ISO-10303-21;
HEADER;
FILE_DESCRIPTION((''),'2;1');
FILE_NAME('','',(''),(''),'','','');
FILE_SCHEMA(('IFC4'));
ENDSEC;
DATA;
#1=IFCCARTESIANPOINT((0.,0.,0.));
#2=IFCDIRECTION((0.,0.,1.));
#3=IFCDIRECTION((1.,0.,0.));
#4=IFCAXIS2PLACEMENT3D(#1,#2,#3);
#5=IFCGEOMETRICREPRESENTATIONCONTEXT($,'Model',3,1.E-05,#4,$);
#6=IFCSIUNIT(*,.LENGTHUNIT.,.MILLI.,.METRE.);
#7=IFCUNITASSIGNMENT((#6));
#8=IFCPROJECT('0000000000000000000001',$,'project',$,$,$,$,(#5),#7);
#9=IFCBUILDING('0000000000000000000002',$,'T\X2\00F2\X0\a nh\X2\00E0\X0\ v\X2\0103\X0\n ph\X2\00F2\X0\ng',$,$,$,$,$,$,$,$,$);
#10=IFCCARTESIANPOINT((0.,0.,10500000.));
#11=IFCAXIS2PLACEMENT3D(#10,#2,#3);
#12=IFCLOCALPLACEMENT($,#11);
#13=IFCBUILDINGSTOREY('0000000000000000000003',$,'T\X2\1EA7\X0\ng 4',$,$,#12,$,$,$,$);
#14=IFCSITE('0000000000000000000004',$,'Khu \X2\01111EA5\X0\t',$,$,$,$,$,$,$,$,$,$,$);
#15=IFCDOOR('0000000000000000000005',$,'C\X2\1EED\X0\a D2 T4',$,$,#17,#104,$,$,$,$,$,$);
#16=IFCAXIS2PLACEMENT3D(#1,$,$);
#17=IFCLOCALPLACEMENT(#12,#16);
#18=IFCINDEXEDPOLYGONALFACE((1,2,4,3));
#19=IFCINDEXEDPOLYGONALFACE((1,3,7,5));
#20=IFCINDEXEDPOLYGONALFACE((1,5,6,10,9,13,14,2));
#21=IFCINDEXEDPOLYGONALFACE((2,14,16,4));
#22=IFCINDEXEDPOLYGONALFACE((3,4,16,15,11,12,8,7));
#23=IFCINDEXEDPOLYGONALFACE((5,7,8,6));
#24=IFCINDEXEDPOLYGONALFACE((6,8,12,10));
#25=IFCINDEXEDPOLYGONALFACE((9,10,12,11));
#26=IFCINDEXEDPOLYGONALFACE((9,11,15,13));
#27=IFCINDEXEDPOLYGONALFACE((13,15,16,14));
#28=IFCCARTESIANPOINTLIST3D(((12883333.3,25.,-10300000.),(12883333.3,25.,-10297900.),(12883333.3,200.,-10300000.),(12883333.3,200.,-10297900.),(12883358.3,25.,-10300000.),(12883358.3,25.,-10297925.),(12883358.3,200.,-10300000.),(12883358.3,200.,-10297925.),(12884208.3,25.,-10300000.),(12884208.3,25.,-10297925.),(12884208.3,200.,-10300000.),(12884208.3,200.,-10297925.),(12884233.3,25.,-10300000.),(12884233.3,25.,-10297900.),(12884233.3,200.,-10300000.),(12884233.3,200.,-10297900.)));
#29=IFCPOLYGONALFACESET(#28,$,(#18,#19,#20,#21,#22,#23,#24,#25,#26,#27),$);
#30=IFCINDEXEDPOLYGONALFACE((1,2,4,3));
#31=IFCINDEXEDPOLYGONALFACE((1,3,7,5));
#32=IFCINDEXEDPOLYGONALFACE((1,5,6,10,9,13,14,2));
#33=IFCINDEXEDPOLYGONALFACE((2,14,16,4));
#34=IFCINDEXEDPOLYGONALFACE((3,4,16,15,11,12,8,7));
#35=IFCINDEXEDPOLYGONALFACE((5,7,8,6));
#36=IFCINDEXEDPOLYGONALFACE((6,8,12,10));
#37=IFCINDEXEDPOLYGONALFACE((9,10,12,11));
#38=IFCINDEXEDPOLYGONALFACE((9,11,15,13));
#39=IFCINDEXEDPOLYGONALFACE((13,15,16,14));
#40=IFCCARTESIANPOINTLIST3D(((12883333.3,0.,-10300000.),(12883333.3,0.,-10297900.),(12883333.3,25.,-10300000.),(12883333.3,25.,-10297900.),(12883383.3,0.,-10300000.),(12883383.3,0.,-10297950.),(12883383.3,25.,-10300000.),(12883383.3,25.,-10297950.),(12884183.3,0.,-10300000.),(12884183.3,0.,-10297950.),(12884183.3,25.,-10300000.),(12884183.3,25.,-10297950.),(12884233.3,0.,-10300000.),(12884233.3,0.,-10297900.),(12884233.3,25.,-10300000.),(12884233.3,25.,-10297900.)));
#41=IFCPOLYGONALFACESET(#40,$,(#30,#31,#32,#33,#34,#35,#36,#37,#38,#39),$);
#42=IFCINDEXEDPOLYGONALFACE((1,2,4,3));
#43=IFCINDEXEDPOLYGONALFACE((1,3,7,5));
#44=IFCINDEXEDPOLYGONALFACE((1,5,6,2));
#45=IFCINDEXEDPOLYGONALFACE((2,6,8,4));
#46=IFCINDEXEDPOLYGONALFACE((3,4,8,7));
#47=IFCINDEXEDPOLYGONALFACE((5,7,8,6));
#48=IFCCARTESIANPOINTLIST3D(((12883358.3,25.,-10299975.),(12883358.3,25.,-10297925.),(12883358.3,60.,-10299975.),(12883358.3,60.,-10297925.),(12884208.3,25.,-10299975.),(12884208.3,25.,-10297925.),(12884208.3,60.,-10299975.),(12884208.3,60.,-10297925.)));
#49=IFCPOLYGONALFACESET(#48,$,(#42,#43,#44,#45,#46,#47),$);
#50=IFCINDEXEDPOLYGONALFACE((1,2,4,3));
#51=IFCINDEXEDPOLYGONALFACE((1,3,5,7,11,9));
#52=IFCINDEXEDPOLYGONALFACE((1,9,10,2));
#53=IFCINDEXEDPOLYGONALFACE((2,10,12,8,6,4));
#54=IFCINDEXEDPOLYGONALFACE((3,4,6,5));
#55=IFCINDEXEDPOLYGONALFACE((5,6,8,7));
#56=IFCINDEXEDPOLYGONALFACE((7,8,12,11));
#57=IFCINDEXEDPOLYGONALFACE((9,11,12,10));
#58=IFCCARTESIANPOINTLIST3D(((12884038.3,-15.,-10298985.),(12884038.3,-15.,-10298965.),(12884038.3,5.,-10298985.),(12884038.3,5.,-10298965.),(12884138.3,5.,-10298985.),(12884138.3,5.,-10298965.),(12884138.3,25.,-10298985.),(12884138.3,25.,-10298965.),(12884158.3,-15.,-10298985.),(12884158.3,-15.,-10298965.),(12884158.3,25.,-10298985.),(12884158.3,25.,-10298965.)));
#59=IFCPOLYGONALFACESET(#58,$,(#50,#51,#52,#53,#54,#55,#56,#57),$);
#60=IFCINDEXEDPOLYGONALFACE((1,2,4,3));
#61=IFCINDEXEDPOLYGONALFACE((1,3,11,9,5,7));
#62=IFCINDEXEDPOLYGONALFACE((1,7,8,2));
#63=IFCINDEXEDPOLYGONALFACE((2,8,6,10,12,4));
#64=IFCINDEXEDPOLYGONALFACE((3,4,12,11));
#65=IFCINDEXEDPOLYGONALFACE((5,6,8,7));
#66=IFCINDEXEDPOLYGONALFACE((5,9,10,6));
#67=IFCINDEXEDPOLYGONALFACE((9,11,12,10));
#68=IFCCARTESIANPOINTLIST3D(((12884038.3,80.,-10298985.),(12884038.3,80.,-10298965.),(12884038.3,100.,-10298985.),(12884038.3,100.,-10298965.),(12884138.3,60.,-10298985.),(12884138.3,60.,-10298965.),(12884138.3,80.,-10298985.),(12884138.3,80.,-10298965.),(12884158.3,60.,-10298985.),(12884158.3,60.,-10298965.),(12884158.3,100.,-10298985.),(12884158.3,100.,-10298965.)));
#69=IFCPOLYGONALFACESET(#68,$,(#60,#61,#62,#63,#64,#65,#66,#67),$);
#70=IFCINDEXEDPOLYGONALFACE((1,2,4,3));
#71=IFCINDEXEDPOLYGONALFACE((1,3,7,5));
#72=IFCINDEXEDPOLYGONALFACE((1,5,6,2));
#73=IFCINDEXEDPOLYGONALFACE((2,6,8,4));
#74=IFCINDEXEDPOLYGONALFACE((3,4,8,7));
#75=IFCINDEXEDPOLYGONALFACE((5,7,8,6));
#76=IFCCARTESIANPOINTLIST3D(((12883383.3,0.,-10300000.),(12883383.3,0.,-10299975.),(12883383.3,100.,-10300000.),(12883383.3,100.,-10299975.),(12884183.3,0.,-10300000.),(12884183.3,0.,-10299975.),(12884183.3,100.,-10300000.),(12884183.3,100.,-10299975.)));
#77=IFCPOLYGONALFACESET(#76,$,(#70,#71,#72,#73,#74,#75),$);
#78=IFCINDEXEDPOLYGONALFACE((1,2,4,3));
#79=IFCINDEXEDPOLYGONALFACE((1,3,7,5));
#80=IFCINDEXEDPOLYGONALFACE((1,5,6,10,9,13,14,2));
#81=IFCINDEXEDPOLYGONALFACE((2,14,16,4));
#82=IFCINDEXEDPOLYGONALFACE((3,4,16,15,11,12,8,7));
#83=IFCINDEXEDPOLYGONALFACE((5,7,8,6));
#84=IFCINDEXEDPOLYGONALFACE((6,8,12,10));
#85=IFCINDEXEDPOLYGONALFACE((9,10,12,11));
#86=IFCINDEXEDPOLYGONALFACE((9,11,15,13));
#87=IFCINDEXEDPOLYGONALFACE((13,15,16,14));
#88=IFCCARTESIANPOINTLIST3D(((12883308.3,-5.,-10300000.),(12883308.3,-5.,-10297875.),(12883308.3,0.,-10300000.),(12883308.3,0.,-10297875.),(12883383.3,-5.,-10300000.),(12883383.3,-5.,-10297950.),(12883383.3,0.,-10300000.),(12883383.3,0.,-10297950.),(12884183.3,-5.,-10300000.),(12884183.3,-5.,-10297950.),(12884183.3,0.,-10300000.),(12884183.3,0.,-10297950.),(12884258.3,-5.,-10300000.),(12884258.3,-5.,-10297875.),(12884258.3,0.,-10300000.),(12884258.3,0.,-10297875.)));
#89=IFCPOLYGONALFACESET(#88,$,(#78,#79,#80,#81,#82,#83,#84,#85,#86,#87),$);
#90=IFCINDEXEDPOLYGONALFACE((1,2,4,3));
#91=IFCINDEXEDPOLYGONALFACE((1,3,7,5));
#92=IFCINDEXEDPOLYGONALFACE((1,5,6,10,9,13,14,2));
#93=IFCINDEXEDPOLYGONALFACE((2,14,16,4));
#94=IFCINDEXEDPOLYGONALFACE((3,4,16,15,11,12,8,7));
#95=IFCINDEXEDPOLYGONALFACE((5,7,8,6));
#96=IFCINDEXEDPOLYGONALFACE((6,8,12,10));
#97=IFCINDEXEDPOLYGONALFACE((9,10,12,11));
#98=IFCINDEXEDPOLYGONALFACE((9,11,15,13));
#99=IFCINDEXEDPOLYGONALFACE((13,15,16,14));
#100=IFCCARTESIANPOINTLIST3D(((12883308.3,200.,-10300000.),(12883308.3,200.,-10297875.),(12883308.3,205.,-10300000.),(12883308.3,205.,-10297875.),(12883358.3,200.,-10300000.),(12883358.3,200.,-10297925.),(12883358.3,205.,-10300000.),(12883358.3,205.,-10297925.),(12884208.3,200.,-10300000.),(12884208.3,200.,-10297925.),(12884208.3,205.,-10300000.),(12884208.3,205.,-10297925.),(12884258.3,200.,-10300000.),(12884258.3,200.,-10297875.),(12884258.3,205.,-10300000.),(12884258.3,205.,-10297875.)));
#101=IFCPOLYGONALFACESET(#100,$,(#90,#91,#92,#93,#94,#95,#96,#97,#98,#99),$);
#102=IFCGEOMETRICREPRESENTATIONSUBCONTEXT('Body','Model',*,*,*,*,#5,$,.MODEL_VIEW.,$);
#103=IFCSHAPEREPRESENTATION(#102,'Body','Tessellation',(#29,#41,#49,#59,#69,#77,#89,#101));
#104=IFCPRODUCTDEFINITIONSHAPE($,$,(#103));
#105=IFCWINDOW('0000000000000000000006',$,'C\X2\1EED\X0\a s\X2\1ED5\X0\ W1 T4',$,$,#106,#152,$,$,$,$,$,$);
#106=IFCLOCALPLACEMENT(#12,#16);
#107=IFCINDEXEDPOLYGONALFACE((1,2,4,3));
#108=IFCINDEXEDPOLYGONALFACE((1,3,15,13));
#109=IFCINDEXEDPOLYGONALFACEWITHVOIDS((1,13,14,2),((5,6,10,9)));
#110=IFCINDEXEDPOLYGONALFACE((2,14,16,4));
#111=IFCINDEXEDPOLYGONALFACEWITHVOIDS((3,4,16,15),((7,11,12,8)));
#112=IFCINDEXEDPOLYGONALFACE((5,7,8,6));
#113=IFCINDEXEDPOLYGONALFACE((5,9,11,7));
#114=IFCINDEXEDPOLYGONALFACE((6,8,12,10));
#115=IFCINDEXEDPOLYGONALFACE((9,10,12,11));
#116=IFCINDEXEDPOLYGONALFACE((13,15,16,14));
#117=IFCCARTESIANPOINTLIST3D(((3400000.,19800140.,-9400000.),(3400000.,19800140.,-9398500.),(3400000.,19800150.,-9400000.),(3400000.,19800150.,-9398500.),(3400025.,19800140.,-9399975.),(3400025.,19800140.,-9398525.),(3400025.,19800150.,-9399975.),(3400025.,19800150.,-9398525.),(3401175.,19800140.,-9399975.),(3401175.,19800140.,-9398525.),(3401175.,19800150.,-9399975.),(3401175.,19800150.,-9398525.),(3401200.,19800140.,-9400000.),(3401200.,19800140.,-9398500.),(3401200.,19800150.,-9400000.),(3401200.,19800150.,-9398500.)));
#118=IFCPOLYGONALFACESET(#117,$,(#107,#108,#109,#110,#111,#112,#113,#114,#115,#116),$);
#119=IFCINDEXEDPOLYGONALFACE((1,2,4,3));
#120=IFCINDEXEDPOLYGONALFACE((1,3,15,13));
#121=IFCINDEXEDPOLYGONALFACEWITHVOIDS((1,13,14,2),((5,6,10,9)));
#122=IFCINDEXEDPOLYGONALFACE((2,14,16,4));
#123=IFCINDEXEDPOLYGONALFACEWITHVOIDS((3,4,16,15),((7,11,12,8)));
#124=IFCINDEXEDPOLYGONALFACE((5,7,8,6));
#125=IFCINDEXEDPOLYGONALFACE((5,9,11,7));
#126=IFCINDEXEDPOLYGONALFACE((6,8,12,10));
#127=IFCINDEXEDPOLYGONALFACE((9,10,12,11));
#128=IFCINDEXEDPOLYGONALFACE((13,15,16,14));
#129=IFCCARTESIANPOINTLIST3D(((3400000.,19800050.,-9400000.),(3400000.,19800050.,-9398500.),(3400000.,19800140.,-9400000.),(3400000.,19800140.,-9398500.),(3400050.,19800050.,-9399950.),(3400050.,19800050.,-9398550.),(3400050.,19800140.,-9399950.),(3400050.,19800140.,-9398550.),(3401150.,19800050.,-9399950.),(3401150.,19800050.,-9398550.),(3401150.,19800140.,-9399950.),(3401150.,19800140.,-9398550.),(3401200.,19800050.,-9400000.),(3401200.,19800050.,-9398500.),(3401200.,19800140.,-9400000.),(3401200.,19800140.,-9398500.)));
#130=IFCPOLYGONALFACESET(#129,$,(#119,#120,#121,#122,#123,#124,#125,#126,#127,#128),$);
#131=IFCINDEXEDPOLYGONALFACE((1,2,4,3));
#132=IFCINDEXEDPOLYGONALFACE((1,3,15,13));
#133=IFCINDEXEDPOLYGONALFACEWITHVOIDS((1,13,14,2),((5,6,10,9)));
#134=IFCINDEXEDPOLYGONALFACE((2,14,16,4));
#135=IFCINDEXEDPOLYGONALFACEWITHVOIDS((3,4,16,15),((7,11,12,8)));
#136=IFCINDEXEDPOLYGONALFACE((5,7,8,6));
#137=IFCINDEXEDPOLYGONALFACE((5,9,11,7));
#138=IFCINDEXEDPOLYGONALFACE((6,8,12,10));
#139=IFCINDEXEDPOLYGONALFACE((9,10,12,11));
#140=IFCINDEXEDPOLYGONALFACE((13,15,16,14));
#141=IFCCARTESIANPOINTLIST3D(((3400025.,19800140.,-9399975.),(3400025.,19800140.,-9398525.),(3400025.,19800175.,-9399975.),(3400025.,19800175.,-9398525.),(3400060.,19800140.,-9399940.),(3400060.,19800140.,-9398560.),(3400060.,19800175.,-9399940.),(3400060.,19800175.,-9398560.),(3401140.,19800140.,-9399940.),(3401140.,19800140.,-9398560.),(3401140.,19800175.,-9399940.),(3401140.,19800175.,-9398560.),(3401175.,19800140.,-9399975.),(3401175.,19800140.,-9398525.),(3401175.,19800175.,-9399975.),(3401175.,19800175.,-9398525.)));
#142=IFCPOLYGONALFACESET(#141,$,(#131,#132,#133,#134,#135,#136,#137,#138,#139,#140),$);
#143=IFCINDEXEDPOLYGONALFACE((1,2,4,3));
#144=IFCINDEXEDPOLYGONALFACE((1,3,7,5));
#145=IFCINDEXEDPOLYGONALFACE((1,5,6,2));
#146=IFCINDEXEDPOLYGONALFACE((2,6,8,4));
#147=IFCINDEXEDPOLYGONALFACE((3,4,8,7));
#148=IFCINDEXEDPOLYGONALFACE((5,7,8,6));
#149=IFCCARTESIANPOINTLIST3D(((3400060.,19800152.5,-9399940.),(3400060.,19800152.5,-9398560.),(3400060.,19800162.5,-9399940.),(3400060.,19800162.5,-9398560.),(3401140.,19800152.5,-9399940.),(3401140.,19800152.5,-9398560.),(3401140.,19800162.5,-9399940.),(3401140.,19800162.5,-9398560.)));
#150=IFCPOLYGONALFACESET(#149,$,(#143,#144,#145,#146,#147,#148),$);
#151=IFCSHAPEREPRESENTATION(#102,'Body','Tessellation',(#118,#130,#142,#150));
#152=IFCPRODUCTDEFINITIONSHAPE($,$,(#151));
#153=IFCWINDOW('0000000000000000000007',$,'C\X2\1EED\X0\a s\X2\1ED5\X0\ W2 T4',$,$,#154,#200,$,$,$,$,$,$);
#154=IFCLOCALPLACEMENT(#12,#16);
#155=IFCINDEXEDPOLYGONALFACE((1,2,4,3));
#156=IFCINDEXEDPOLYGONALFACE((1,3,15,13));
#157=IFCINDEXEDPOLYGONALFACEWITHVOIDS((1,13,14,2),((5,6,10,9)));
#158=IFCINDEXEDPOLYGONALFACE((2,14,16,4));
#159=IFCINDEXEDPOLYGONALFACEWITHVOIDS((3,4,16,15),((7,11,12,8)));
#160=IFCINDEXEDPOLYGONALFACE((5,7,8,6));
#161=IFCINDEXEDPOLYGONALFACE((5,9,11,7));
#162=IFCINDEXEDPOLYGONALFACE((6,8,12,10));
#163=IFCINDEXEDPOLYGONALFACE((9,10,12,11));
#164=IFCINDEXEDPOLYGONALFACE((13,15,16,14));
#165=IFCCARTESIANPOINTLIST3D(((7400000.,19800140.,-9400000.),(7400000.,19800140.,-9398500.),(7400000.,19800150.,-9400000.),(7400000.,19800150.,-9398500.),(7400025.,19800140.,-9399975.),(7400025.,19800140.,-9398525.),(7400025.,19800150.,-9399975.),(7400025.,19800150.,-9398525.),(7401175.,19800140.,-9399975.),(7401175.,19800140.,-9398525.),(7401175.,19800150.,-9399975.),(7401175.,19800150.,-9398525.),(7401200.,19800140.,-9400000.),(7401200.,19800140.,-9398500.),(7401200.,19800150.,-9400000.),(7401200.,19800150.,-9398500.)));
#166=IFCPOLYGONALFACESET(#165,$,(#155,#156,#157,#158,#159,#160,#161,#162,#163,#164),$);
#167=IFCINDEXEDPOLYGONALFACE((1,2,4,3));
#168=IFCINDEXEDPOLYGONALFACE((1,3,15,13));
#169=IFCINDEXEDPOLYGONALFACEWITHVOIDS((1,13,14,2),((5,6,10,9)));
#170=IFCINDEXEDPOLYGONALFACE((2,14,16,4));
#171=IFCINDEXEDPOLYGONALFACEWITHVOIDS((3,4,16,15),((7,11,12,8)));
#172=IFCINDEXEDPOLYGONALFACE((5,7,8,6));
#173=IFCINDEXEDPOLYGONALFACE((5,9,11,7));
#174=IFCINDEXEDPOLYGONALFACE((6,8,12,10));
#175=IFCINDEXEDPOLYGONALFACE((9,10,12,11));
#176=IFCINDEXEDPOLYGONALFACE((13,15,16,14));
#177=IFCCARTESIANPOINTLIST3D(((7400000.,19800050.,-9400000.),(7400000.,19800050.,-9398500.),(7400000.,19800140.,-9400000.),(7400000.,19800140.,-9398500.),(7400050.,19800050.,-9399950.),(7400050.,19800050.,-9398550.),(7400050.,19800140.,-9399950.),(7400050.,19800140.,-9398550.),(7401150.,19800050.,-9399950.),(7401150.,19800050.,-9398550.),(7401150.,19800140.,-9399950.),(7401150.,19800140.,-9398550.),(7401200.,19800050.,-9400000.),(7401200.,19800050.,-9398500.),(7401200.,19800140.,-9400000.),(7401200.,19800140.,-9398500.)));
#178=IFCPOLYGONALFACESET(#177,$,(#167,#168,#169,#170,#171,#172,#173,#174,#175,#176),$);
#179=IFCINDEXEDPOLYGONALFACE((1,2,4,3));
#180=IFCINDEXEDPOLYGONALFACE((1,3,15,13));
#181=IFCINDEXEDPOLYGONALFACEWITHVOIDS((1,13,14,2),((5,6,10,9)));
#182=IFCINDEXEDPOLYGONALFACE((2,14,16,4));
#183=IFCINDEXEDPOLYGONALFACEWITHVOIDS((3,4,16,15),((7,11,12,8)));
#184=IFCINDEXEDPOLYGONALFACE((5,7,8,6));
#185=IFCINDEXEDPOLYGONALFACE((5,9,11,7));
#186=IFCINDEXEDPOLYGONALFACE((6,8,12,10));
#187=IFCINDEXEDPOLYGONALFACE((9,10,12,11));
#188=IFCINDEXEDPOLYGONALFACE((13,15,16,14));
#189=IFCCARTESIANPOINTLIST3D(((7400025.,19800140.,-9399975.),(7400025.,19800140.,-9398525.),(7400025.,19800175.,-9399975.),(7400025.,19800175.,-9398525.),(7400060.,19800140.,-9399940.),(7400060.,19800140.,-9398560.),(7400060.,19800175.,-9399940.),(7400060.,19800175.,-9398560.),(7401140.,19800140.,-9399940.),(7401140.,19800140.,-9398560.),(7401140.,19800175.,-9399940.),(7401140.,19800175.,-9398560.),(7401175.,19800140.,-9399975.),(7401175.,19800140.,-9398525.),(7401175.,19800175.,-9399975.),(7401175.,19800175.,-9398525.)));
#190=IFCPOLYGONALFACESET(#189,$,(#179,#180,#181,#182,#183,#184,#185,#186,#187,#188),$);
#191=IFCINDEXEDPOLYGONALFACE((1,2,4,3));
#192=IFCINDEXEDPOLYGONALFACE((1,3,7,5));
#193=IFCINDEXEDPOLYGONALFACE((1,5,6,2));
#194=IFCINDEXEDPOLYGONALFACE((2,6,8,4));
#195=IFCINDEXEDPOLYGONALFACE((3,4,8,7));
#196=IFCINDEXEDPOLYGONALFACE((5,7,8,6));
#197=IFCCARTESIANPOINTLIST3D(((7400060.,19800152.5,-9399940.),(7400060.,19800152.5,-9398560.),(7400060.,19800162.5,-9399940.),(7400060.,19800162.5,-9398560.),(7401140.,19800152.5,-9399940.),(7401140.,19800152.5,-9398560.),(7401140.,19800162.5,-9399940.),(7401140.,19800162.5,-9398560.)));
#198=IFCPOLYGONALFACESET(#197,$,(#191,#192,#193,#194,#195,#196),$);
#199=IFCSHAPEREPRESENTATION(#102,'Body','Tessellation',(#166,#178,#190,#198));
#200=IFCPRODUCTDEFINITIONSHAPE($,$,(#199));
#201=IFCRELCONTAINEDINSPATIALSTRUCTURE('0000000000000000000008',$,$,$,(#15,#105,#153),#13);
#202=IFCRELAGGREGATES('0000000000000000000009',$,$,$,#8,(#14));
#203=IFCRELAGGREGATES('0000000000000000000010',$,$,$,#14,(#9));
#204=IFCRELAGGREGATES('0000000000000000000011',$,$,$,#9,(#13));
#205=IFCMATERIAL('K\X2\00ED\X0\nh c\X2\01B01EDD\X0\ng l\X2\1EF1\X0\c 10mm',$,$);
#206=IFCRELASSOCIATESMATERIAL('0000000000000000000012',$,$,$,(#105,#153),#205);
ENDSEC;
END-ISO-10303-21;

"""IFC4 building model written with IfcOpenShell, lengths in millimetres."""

from ifc_helpers import new_model, si_unit, frame, origin_with_axes, place, context, subcontext, project, spatial, line, indexed_curve, outline, extrude, material, element, save


model = new_model("IFC4")

# Units and contexts
model_context = context("Model", 3, precision=1e-05, world=origin_with_axes())
body_context = subcontext(model_context, "Body", "Model", "MODEL_VIEW")
ifc_project = project(units=[si_unit("LENGTHUNIT", "METRE", prefix="MILLI")], contexts=[model_context])

# Site, building, storey
site = spatial("IfcSite", under=ifc_project, Name="Khu đất")
building = spatial("IfcBuilding", under=site, Name="Tòa nhà văn phòng")
storey_placement = place(None, frame((0.0, 0.0, 10500000.0), z_axis=(0.0, 0.0, 1.0), x_axis=(1.0, 0.0, 0.0)))
storey = spatial("IfcBuildingStorey", under=building, at=storey_placement, Name="Tầng 4")

# Door
door_1_placement = place(storey_placement, frame((12883333.3, 0.0, -10300000.0), z_axis=(0.0, 0.0, 1.0), x_axis=(1.0, 0.0, 0.0)))
element("IfcDoor", 1, at=door_1_placement, inside=storey, Name="Cửa D2 T4", context=body_context, shape_type="SolidModel", body=[
    extrude(outline(indexed_curve([(0.0, 0.0), (0.0, 2100.0), (900.0, 2100.0), (900.0, 0.0), (875.0, 0.0), (875.0, 2075.0), (25.0, 2075.0), (25.0, 0.0)], segments=[line(1, 2, 3, 4, 5, 6, 7, 8, 1)])), frame((0.0, 25.0, 0.0), z_axis=(0.0, -1.0, 0.0), x_axis=(1.0, 0.0, 0.0)), (0.0, 0.0, -1.0), 175.0),
    extrude(outline(indexed_curve([(0.0, 0.0), (0.0, 2100.0), (900.0, 2100.0), (900.0, 0.0), (850.0, 0.0), (850.0, 2050.0), (50.0, 2050.0), (50.0, 0.0)], segments=[line(1, 2, 3, 4, 5, 6, 7, 8, 1)])), frame((0.0, 0.0, 0.0), z_axis=(0.0, -1.0, 0.0), x_axis=(1.0, 0.0, 0.0)), (0.0, 0.0, -1.0), 25.0),
    extrude(outline(indexed_curve([(0.0, 0.0), (850.0, 0.0), (850.0, 35.0), (0.0, 35.0)], segments=[line(1, 2, 3, 4, 1)])), frame((25.0, 25.0, 25.0), z_axis=(0.0, 0.0, 1.0), x_axis=(1.0, 0.0, 0.0)), (0.0, 0.0, 1.0), 2050.0),
    extrude(outline(indexed_curve([(0.0, 0.0), (0.0, -40.0), (-120.0, -40.0), (-120.0, -20.0), (-20.0, -20.0), (-20.0, 0.0)], segments=[line(1, 2, 3, 4, 5, 6, 1)])), frame((825.0, 25.0, 1015.0), z_axis=(0.0, 0.0, 1.0), x_axis=(1.0, 0.0, 0.0)), (0.0, 0.0, 1.0), 20.0),
    extrude(outline(indexed_curve([(0.0, 0.0), (0.0, 40.0), (-120.0, 40.0), (-120.0, 20.0), (-20.0, 20.0), (-20.0, 0.0)], segments=[line(1, 2, 3, 4, 5, 6, 1)])), frame((825.0, 60.0, 1015.0), z_axis=(0.0, 0.0, 1.0), x_axis=(1.0, 0.0, 0.0)), (0.0, 0.0, 1.0), 20.0),
    extrude(outline(indexed_curve([(0.0, 0.0), (800.0, 0.0), (800.0, 100.0), (0.0, 100.0)], segments=[line(1, 2, 3, 4, 1)])), frame((50.0, 0.0, 0.0), z_axis=(0.0, 0.0, 1.0), x_axis=(1.0, 0.0, 0.0)), (0.0, 0.0, 1.0), 25.0),
    extrude(outline(indexed_curve([(0.0, 0.0), (0.0, 2125.0), (950.0, 2125.0), (950.0, 0.0), (875.0, 0.0), (875.0, 2050.0), (75.0, 2050.0), (75.0, 0.0)], segments=[line(1, 2, 3, 4, 5, 6, 7, 8, 1)])), frame((-25.0, -5.0, 0.0), z_axis=(0.0, -1.0, 0.0), x_axis=(1.0, 0.0, 0.0)), (0.0, 0.0, -1.0), 5.0),
    extrude(outline(indexed_curve([(0.0, 0.0), (0.0, 2125.0), (950.0, 2125.0), (950.0, 0.0), (900.0, 0.0), (900.0, 2075.0), (50.0, 2075.0), (50.0, 0.0)], segments=[line(1, 2, 3, 4, 5, 6, 7, 8, 1)])), frame((-25.0, 200.0, 0.0), z_axis=(0.0, -1.0, 0.0), x_axis=(1.0, 0.0, 0.0)), (0.0, 0.0, -1.0), 5.0),
])

# Windows
ifc_material_1 = material(Name="Kính cường lực 10mm")
for number, where, z_axis, x_axis, name in (
    (2, (3400000.0, 19800000.0, -9400000.0), (0.0, 0.0, 1.0), (1.0, 0.0, 0.0), "Cửa sổ W1 T4"),
    (3, (7400000.0, 19800000.0, -9400000.0), (0.0, 0.0, 1.0), (1.0, 0.0, 0.0), "Cửa sổ W2 T4"),
):
    element("IfcWindow", number, at=place(storey_placement, frame(where, z_axis=z_axis, x_axis=x_axis)), inside=storey, material=ifc_material_1, Name=name, context=body_context, shape_type="SolidModel", body=[
        extrude(outline(indexed_curve([(0.0, 0.0), (1200.0, 0.0), (1200.0, 1500.0), (0.0, 1500.0)], segments=[line(1, 2, 3, 4, 1)]), holes=[indexed_curve([(25.0, 25.0), (1175.0, 25.0), (1175.0, 1475.0), (25.0, 1475.0)], segments=[line(1, 2, 3, 4, 1)])]), frame((0.0, 140.0, 0.0), z_axis=(0.0, -1.0, 0.0), x_axis=(1.0, 0.0, 0.0)), (0.0, 0.0, -1.0), 10.0),
        extrude(outline(indexed_curve([(0.0, 0.0), (1200.0, 0.0), (1200.0, 1500.0), (0.0, 1500.0)], segments=[line(1, 2, 3, 4, 1)]), holes=[indexed_curve([(50.0, 50.0), (1150.0, 50.0), (1150.0, 1450.0), (50.0, 1450.0)], segments=[line(1, 2, 3, 4, 1)])]), frame((0.0, 50.0, 0.0), z_axis=(0.0, -1.0, 0.0), x_axis=(1.0, 0.0, 0.0)), (0.0, 0.0, -1.0), 90.0),
        extrude(outline(indexed_curve([(0.0, 0.0), (1150.0, 0.0), (1150.0, 1450.0), (0.0, 1450.0)], segments=[line(1, 2, 3, 4, 1)]), holes=[indexed_curve([(35.0, 35.0), (1115.0, 35.0), (1115.0, 1415.0), (35.0, 1415.0)], segments=[line(1, 2, 3, 4, 1)])]), frame((25.0, 140.0, 25.0), z_axis=(0.0, -1.0, 0.0), x_axis=(1.0, 0.0, 0.0)), (0.0, 0.0, -1.0), 35.0),
        extrude(outline(indexed_curve([(35.0, 35.0), (1115.0, 35.0), (1115.0, 1415.0), (35.0, 1415.0)], segments=[line(1, 2, 3, 4, 1)])), frame((25.0, 152.5, 25.0), z_axis=(0.0, -1.0, 0.0), x_axis=(1.0, 0.0, 0.0)), (0.0, 0.0, -1.0), 10.0),
    ])

save(model, "model.ifc")
